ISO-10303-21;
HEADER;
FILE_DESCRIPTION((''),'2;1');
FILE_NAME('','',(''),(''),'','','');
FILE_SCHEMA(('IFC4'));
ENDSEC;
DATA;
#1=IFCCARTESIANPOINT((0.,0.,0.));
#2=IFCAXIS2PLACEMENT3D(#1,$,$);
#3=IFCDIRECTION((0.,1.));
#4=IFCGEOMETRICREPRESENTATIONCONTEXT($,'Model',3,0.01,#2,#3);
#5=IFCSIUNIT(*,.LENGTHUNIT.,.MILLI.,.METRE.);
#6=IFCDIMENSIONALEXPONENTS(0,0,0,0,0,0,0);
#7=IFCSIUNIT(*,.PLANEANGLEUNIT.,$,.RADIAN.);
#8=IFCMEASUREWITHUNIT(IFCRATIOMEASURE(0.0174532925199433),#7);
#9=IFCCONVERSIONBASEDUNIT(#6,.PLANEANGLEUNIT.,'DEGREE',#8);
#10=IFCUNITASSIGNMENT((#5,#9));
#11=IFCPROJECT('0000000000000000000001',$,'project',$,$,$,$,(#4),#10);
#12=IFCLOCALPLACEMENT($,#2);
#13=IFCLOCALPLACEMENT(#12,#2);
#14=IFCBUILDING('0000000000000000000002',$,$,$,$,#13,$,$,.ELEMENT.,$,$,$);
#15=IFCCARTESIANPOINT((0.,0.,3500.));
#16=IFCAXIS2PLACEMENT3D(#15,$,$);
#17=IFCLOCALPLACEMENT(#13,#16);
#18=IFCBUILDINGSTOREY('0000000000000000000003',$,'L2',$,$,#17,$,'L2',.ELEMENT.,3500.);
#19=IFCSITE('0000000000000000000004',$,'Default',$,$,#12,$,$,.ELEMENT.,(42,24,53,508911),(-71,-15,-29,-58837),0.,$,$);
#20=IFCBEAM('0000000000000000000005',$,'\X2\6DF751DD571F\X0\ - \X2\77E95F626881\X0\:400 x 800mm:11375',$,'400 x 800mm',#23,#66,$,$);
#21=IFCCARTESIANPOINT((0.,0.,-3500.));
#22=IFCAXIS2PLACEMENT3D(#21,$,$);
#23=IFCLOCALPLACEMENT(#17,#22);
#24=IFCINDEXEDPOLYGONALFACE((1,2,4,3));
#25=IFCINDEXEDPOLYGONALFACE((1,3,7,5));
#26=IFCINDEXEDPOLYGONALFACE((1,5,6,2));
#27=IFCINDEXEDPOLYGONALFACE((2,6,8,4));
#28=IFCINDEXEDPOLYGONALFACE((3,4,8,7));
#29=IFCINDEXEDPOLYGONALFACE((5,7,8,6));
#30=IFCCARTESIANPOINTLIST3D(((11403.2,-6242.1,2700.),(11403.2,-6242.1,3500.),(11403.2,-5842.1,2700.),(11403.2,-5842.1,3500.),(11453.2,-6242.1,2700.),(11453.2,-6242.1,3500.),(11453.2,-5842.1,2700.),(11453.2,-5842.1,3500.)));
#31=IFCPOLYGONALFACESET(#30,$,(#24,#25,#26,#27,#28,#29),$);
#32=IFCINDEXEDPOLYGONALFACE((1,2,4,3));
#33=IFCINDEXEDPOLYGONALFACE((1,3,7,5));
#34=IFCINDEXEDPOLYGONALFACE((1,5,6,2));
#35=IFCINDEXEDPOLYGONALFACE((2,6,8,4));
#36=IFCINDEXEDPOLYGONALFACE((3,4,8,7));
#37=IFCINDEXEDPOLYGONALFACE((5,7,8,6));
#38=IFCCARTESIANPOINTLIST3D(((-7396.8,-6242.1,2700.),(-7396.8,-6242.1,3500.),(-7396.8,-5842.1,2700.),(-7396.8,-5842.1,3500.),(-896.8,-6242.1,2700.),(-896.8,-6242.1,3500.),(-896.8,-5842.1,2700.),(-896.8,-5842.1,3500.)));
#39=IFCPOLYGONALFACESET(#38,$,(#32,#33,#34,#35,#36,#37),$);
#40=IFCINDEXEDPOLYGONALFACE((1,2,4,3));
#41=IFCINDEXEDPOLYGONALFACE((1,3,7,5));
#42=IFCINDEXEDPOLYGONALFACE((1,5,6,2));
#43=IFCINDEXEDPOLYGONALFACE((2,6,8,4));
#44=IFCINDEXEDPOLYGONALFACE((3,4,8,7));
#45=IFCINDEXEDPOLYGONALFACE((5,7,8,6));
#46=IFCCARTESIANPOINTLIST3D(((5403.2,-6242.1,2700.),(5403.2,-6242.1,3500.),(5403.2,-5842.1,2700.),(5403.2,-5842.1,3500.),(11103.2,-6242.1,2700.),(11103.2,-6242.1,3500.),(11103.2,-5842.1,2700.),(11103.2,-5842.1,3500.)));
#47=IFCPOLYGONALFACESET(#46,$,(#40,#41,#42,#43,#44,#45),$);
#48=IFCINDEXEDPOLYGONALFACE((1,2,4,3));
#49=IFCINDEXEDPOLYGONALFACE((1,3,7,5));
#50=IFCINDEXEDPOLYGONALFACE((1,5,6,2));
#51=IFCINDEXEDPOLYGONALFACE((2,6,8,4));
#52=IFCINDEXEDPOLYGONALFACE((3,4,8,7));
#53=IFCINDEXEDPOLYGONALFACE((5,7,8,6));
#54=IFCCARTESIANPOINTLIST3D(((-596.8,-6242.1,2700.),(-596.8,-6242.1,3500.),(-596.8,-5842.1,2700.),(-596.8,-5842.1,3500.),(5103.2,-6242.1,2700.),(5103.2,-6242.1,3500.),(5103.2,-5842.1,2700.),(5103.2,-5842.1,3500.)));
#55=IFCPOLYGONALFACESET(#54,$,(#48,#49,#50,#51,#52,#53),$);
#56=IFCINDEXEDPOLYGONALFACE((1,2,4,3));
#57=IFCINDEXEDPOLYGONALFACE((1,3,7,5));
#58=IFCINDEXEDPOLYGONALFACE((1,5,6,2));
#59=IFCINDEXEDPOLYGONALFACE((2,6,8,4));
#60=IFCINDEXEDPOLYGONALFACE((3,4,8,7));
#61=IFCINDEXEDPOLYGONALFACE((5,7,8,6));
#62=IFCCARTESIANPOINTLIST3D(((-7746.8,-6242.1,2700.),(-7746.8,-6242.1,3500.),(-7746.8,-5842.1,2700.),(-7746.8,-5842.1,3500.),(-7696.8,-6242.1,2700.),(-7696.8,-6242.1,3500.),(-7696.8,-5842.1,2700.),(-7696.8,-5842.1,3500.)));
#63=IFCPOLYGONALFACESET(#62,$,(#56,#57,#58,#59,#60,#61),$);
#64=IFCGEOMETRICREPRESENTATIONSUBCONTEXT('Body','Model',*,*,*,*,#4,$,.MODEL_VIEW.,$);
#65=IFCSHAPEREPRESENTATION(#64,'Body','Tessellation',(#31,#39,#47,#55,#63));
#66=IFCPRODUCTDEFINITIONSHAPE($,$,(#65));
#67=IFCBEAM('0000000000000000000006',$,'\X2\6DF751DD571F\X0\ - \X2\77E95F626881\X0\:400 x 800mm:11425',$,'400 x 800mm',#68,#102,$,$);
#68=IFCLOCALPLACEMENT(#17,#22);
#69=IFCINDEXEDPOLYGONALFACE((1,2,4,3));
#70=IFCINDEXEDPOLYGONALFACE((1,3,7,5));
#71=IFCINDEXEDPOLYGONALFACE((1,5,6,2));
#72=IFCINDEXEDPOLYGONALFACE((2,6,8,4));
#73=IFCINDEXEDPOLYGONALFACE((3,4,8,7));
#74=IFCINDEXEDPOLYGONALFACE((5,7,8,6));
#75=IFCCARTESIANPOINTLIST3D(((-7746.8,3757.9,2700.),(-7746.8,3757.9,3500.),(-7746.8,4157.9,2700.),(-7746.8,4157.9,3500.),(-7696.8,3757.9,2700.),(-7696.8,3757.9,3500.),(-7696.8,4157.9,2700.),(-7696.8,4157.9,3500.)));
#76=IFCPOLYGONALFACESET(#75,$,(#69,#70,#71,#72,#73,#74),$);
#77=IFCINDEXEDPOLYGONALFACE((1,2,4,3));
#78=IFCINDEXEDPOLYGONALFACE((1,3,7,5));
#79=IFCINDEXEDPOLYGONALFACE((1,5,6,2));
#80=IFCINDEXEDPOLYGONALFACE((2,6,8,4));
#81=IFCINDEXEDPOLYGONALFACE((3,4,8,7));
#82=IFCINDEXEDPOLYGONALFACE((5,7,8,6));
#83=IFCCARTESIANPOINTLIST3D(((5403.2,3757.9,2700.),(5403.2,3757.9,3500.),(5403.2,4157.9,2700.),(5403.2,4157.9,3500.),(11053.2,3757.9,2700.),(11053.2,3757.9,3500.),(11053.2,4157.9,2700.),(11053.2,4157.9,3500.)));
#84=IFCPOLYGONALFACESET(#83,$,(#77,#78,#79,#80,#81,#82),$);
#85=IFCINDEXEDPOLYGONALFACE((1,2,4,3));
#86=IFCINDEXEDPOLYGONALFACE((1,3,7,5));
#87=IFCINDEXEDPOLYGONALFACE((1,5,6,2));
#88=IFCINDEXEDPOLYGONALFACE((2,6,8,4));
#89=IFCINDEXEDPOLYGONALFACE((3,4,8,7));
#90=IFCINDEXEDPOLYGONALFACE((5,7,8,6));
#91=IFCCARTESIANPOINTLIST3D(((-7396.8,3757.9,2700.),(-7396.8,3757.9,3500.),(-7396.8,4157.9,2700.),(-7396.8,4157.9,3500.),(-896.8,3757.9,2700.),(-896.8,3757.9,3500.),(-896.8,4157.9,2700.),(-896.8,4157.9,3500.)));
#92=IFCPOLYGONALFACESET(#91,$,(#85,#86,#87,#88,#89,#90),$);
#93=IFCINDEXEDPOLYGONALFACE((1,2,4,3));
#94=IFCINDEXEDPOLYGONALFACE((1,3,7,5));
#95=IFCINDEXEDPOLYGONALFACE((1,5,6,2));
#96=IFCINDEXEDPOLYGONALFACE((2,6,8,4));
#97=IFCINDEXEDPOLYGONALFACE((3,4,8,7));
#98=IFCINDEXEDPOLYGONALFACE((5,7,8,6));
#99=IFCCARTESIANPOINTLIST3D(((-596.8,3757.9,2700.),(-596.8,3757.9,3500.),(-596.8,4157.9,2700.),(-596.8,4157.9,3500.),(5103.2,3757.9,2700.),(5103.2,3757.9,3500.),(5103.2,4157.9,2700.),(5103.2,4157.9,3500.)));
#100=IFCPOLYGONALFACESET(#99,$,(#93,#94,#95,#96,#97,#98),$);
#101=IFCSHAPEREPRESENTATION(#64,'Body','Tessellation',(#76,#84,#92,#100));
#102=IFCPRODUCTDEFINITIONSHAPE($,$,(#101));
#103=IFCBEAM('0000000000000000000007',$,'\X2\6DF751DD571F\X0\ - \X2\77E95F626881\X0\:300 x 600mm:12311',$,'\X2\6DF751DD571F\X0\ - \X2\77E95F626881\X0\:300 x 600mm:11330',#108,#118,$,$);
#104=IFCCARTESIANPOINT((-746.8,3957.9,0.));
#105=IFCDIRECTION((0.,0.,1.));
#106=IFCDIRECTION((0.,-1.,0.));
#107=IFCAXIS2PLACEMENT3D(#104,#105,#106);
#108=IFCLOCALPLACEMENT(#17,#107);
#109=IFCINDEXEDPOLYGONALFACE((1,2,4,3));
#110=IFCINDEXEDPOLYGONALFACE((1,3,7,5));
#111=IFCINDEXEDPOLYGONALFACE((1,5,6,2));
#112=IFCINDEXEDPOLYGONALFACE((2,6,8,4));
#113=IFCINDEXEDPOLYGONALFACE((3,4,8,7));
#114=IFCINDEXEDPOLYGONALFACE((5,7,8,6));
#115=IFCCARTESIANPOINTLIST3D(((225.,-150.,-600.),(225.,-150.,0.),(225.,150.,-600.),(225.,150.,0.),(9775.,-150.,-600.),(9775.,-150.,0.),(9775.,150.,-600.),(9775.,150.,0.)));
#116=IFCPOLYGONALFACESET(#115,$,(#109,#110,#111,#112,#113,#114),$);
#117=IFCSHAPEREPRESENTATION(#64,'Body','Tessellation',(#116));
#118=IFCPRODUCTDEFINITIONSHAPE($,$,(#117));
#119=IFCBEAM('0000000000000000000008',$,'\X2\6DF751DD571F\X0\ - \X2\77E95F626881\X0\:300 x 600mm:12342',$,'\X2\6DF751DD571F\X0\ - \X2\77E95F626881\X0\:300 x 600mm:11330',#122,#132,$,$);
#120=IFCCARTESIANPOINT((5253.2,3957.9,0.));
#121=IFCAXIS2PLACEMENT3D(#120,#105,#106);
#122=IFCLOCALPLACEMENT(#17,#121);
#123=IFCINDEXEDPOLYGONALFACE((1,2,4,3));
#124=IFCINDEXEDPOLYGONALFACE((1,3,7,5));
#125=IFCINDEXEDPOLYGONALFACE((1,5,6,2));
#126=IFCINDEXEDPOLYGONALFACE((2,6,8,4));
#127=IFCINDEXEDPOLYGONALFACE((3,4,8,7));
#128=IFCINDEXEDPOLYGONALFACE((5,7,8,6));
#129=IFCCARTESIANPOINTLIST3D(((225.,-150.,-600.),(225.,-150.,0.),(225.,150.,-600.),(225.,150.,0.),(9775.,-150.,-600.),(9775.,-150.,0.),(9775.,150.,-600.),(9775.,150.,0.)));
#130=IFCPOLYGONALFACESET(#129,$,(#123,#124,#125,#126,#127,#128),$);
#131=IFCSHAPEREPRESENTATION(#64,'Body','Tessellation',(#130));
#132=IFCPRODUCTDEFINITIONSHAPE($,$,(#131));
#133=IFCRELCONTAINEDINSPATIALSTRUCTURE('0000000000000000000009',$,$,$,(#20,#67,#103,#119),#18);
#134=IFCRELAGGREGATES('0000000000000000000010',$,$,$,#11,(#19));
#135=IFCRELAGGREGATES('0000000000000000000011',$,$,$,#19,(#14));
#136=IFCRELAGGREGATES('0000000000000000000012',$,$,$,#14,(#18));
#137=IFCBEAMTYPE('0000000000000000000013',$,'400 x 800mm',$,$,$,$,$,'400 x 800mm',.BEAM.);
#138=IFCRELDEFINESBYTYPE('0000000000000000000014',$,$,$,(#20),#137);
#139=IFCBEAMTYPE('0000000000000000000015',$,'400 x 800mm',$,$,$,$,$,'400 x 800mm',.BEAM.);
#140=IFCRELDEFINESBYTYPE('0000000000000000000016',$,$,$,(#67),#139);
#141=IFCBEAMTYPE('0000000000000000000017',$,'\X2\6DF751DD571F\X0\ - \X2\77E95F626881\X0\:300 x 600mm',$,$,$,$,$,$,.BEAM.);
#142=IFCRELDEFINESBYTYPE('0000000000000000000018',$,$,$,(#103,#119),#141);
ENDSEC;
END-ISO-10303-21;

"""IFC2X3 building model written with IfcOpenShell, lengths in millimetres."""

from ifc_helpers import new_model, entity, si_unit, converted_unit, direction, frame, frame_2d, origin, place, context, subcontext, project, spatial, rectangle, extrude, source, transform, mapped, type_object, type_shapes, element, save


model = new_model("IFC2X3")

# Units and contexts
model_context = context("Model", 3, precision=0.01, world=origin(), true_north=direction((0.0, 1.0)))
body_context = subcontext(model_context, "Body", "Model", "MODEL_VIEW")
ifc_project = project(units=[si_unit("LENGTHUNIT", "METRE", prefix="MILLI"), converted_unit("PLANEANGLEUNIT", "DEGREE", entity("IfcRatioMeasure", 0.0174532925199433), si_unit("PLANEANGLEUNIT", "RADIAN"), dimensions=[0, 0, 0, 0, 0, 0, 0])], contexts=[model_context])

# Site, building, storey
site_placement = place(None, origin())
site = spatial("IfcSite", under=ifc_project, at=site_placement, Name="Default", CompositionType="ELEMENT", RefLatitude=(42, 24, 53, 508911), RefLongitude=(-71, -15, -29, -58837), RefElevation=0.0)
building_placement = place(site_placement, origin())
building = spatial("IfcBuilding", under=site, at=building_placement, CompositionType="ELEMENT")
storey_placement = place(building_placement, frame((0.0, 0.0, 3500.0)))
storey = spatial("IfcBuildingStorey", under=building, at=storey_placement, Name="L2", LongName="L2", CompositionType="ELEMENT", Elevation=3500.0)

# Beams
beam_type_1 = type_object("IfcBeamType", Name="400 x 800mm", ElementType="400 x 800mm", PredefinedType="BEAM")
shared_shape_1 = source(origin(), body_context, "Body", "SweptSolid", [
    extrude(rectangle(XDim=50.0, YDim=400.0, at=frame_2d((0.0, 0.0), x_axis=(1.0, 0.0))), frame((11428.2, -6042.1, 2700.0), z_axis=(0.0, 0.0, 1.0), x_axis=(-1.0, 0.0, 0.0)), (0.0, 0.0, 1.0), 800.0),
    extrude(rectangle(XDim=6500.0, YDim=400.0, at=frame_2d((640.0, -40.0), x_axis=(1.0, 0.0))), frame((-4786.8, -6002.1, 2700.0)), (0.0, 0.0, 1.0), 800.0),
    extrude(rectangle(XDim=5700.0, YDim=400.0, at=frame_2d((560.0, 40.0), x_axis=(1.0, 0.0))), frame((8813.2, -6002.1, 2700.0), z_axis=(0.0, 0.0, 1.0), x_axis=(-1.0, 0.0, 0.0)), (0.0, 0.0, 1.0), 800.0),
    extrude(rectangle(XDim=5700.0, YDim=400.0, at=frame_2d((0.0, 0.0), x_axis=(1.0, 0.0))), frame((2253.2, -6042.1, 2700.0)), (0.0, 0.0, 1.0), 800.0),
    extrude(rectangle(XDim=50.0, YDim=400.0, at=frame_2d((0.0, 0.0), x_axis=(1.0, 0.0))), frame((-7721.8, -6042.1, 2700.0)), (0.0, 0.0, 1.0), 800.0),
])
type_shapes(beam_type_1, [shared_shape_1])
beam_1_placement = place(storey_placement, frame((0.0, 0.0, -3500.0)))
element("IfcBeam", 1, at=beam_1_placement, inside=storey, type_object=beam_type_1, Name="混凝土 - 矩形梁:400 x 800mm:11375", ObjectType="400 x 800mm", context=body_context, shape_type="MappedRepresentation", body=[
    mapped(shared_shape_1, transform((0.0, 0.0, 0.0), scale=1.0)),
])
beam_type_2 = type_object("IfcBeamType", Name="400 x 800mm", ElementType="400 x 800mm", PredefinedType="BEAM")
shared_shape_2 = source(origin(), body_context, "Body", "SweptSolid", [
    extrude(rectangle(XDim=50.0, YDim=400.0, at=frame_2d((0.0, 0.0), x_axis=(1.0, 0.0))), frame((-7721.8, 3957.9, 2700.0)), (0.0, 0.0, 1.0), 800.0),
    extrude(rectangle(XDim=5650.0, YDim=400.0, at=frame_2d((0.0, 0.0), x_axis=(1.0, 0.0))), frame((8228.2, 3957.9, 2700.0), z_axis=(0.0, 0.0, 1.0), x_axis=(-1.0, 0.0, 0.0)), (0.0, 0.0, 1.0), 800.0),
    extrude(rectangle(XDim=6500.0, YDim=400.0, at=frame_2d((640.0, 40.0), x_axis=(1.0, 0.0))), frame((-4786.8, 3917.9, 2700.0)), (0.0, 0.0, 1.0), 800.0),
    extrude(rectangle(XDim=5700.0, YDim=400.0, at=frame_2d((0.0, 0.0), x_axis=(1.0, 0.0))), frame((2253.2, 3957.9, 2700.0), z_axis=(0.0, 0.0, 1.0), x_axis=(-1.0, 0.0, 0.0)), (0.0, 0.0, 1.0), 800.0),
])
type_shapes(beam_type_2, [shared_shape_2])
beam_2_placement = place(storey_placement, frame((0.0, 0.0, -3500.0)))
element("IfcBeam", 2, at=beam_2_placement, inside=storey, type_object=beam_type_2, Name="混凝土 - 矩形梁:400 x 800mm:11425", ObjectType="400 x 800mm", context=body_context, shape_type="MappedRepresentation", body=[
    mapped(shared_shape_2, transform((0.0, 0.0, 0.0), scale=1.0)),
])
beam_type_3 = type_object("IfcBeamType", Name="混凝土 - 矩形梁:300 x 600mm", PredefinedType="BEAM")
beam_3_placement = place(storey_placement, frame((-746.8, 3957.9, 0.0), z_axis=(0.0, 0.0, 1.0), x_axis=(0.0, -1.0, 0.0)))
element("IfcBeam", 3, at=beam_3_placement, inside=storey, type_object=beam_type_3, Name="混凝土 - 矩形梁:300 x 600mm:12311", ObjectType="混凝土 - 矩形梁:300 x 600mm:11330", context=body_context, shape_type="SweptSolid", body=[
    extrude(rectangle(XDim=600.0, YDim=300.0, at=frame_2d((0.0, 0.0), x_axis=(1.0, 0.0))), frame((225.0, 0.0, -300.0), z_axis=(1.0, 0.0, 0.0), x_axis=(0.0, 0.0, -1.0)), (0.0, 0.0, 1.0), 9550.0),
])
beam_4_placement = place(storey_placement, frame((5253.2, 3957.9, 0.0), z_axis=(0.0, 0.0, 1.0), x_axis=(0.0, -1.0, 0.0)))
element("IfcBeam", 4, at=beam_4_placement, inside=storey, type_object=beam_type_3, Name="混凝土 - 矩形梁:300 x 600mm:12342", ObjectType="混凝土 - 矩形梁:300 x 600mm:11330", context=body_context, shape_type="SweptSolid", body=[
    extrude(rectangle(XDim=600.0, YDim=300.0, at=frame_2d((0.0, 0.0), x_axis=(1.0, 0.0))), frame((225.0, 0.0, -300.0), z_axis=(1.0, 0.0, 0.0), x_axis=(0.0, 0.0, -1.0)), (0.0, 0.0, 1.0), 9550.0),
])

save(model, "model.ifc")
